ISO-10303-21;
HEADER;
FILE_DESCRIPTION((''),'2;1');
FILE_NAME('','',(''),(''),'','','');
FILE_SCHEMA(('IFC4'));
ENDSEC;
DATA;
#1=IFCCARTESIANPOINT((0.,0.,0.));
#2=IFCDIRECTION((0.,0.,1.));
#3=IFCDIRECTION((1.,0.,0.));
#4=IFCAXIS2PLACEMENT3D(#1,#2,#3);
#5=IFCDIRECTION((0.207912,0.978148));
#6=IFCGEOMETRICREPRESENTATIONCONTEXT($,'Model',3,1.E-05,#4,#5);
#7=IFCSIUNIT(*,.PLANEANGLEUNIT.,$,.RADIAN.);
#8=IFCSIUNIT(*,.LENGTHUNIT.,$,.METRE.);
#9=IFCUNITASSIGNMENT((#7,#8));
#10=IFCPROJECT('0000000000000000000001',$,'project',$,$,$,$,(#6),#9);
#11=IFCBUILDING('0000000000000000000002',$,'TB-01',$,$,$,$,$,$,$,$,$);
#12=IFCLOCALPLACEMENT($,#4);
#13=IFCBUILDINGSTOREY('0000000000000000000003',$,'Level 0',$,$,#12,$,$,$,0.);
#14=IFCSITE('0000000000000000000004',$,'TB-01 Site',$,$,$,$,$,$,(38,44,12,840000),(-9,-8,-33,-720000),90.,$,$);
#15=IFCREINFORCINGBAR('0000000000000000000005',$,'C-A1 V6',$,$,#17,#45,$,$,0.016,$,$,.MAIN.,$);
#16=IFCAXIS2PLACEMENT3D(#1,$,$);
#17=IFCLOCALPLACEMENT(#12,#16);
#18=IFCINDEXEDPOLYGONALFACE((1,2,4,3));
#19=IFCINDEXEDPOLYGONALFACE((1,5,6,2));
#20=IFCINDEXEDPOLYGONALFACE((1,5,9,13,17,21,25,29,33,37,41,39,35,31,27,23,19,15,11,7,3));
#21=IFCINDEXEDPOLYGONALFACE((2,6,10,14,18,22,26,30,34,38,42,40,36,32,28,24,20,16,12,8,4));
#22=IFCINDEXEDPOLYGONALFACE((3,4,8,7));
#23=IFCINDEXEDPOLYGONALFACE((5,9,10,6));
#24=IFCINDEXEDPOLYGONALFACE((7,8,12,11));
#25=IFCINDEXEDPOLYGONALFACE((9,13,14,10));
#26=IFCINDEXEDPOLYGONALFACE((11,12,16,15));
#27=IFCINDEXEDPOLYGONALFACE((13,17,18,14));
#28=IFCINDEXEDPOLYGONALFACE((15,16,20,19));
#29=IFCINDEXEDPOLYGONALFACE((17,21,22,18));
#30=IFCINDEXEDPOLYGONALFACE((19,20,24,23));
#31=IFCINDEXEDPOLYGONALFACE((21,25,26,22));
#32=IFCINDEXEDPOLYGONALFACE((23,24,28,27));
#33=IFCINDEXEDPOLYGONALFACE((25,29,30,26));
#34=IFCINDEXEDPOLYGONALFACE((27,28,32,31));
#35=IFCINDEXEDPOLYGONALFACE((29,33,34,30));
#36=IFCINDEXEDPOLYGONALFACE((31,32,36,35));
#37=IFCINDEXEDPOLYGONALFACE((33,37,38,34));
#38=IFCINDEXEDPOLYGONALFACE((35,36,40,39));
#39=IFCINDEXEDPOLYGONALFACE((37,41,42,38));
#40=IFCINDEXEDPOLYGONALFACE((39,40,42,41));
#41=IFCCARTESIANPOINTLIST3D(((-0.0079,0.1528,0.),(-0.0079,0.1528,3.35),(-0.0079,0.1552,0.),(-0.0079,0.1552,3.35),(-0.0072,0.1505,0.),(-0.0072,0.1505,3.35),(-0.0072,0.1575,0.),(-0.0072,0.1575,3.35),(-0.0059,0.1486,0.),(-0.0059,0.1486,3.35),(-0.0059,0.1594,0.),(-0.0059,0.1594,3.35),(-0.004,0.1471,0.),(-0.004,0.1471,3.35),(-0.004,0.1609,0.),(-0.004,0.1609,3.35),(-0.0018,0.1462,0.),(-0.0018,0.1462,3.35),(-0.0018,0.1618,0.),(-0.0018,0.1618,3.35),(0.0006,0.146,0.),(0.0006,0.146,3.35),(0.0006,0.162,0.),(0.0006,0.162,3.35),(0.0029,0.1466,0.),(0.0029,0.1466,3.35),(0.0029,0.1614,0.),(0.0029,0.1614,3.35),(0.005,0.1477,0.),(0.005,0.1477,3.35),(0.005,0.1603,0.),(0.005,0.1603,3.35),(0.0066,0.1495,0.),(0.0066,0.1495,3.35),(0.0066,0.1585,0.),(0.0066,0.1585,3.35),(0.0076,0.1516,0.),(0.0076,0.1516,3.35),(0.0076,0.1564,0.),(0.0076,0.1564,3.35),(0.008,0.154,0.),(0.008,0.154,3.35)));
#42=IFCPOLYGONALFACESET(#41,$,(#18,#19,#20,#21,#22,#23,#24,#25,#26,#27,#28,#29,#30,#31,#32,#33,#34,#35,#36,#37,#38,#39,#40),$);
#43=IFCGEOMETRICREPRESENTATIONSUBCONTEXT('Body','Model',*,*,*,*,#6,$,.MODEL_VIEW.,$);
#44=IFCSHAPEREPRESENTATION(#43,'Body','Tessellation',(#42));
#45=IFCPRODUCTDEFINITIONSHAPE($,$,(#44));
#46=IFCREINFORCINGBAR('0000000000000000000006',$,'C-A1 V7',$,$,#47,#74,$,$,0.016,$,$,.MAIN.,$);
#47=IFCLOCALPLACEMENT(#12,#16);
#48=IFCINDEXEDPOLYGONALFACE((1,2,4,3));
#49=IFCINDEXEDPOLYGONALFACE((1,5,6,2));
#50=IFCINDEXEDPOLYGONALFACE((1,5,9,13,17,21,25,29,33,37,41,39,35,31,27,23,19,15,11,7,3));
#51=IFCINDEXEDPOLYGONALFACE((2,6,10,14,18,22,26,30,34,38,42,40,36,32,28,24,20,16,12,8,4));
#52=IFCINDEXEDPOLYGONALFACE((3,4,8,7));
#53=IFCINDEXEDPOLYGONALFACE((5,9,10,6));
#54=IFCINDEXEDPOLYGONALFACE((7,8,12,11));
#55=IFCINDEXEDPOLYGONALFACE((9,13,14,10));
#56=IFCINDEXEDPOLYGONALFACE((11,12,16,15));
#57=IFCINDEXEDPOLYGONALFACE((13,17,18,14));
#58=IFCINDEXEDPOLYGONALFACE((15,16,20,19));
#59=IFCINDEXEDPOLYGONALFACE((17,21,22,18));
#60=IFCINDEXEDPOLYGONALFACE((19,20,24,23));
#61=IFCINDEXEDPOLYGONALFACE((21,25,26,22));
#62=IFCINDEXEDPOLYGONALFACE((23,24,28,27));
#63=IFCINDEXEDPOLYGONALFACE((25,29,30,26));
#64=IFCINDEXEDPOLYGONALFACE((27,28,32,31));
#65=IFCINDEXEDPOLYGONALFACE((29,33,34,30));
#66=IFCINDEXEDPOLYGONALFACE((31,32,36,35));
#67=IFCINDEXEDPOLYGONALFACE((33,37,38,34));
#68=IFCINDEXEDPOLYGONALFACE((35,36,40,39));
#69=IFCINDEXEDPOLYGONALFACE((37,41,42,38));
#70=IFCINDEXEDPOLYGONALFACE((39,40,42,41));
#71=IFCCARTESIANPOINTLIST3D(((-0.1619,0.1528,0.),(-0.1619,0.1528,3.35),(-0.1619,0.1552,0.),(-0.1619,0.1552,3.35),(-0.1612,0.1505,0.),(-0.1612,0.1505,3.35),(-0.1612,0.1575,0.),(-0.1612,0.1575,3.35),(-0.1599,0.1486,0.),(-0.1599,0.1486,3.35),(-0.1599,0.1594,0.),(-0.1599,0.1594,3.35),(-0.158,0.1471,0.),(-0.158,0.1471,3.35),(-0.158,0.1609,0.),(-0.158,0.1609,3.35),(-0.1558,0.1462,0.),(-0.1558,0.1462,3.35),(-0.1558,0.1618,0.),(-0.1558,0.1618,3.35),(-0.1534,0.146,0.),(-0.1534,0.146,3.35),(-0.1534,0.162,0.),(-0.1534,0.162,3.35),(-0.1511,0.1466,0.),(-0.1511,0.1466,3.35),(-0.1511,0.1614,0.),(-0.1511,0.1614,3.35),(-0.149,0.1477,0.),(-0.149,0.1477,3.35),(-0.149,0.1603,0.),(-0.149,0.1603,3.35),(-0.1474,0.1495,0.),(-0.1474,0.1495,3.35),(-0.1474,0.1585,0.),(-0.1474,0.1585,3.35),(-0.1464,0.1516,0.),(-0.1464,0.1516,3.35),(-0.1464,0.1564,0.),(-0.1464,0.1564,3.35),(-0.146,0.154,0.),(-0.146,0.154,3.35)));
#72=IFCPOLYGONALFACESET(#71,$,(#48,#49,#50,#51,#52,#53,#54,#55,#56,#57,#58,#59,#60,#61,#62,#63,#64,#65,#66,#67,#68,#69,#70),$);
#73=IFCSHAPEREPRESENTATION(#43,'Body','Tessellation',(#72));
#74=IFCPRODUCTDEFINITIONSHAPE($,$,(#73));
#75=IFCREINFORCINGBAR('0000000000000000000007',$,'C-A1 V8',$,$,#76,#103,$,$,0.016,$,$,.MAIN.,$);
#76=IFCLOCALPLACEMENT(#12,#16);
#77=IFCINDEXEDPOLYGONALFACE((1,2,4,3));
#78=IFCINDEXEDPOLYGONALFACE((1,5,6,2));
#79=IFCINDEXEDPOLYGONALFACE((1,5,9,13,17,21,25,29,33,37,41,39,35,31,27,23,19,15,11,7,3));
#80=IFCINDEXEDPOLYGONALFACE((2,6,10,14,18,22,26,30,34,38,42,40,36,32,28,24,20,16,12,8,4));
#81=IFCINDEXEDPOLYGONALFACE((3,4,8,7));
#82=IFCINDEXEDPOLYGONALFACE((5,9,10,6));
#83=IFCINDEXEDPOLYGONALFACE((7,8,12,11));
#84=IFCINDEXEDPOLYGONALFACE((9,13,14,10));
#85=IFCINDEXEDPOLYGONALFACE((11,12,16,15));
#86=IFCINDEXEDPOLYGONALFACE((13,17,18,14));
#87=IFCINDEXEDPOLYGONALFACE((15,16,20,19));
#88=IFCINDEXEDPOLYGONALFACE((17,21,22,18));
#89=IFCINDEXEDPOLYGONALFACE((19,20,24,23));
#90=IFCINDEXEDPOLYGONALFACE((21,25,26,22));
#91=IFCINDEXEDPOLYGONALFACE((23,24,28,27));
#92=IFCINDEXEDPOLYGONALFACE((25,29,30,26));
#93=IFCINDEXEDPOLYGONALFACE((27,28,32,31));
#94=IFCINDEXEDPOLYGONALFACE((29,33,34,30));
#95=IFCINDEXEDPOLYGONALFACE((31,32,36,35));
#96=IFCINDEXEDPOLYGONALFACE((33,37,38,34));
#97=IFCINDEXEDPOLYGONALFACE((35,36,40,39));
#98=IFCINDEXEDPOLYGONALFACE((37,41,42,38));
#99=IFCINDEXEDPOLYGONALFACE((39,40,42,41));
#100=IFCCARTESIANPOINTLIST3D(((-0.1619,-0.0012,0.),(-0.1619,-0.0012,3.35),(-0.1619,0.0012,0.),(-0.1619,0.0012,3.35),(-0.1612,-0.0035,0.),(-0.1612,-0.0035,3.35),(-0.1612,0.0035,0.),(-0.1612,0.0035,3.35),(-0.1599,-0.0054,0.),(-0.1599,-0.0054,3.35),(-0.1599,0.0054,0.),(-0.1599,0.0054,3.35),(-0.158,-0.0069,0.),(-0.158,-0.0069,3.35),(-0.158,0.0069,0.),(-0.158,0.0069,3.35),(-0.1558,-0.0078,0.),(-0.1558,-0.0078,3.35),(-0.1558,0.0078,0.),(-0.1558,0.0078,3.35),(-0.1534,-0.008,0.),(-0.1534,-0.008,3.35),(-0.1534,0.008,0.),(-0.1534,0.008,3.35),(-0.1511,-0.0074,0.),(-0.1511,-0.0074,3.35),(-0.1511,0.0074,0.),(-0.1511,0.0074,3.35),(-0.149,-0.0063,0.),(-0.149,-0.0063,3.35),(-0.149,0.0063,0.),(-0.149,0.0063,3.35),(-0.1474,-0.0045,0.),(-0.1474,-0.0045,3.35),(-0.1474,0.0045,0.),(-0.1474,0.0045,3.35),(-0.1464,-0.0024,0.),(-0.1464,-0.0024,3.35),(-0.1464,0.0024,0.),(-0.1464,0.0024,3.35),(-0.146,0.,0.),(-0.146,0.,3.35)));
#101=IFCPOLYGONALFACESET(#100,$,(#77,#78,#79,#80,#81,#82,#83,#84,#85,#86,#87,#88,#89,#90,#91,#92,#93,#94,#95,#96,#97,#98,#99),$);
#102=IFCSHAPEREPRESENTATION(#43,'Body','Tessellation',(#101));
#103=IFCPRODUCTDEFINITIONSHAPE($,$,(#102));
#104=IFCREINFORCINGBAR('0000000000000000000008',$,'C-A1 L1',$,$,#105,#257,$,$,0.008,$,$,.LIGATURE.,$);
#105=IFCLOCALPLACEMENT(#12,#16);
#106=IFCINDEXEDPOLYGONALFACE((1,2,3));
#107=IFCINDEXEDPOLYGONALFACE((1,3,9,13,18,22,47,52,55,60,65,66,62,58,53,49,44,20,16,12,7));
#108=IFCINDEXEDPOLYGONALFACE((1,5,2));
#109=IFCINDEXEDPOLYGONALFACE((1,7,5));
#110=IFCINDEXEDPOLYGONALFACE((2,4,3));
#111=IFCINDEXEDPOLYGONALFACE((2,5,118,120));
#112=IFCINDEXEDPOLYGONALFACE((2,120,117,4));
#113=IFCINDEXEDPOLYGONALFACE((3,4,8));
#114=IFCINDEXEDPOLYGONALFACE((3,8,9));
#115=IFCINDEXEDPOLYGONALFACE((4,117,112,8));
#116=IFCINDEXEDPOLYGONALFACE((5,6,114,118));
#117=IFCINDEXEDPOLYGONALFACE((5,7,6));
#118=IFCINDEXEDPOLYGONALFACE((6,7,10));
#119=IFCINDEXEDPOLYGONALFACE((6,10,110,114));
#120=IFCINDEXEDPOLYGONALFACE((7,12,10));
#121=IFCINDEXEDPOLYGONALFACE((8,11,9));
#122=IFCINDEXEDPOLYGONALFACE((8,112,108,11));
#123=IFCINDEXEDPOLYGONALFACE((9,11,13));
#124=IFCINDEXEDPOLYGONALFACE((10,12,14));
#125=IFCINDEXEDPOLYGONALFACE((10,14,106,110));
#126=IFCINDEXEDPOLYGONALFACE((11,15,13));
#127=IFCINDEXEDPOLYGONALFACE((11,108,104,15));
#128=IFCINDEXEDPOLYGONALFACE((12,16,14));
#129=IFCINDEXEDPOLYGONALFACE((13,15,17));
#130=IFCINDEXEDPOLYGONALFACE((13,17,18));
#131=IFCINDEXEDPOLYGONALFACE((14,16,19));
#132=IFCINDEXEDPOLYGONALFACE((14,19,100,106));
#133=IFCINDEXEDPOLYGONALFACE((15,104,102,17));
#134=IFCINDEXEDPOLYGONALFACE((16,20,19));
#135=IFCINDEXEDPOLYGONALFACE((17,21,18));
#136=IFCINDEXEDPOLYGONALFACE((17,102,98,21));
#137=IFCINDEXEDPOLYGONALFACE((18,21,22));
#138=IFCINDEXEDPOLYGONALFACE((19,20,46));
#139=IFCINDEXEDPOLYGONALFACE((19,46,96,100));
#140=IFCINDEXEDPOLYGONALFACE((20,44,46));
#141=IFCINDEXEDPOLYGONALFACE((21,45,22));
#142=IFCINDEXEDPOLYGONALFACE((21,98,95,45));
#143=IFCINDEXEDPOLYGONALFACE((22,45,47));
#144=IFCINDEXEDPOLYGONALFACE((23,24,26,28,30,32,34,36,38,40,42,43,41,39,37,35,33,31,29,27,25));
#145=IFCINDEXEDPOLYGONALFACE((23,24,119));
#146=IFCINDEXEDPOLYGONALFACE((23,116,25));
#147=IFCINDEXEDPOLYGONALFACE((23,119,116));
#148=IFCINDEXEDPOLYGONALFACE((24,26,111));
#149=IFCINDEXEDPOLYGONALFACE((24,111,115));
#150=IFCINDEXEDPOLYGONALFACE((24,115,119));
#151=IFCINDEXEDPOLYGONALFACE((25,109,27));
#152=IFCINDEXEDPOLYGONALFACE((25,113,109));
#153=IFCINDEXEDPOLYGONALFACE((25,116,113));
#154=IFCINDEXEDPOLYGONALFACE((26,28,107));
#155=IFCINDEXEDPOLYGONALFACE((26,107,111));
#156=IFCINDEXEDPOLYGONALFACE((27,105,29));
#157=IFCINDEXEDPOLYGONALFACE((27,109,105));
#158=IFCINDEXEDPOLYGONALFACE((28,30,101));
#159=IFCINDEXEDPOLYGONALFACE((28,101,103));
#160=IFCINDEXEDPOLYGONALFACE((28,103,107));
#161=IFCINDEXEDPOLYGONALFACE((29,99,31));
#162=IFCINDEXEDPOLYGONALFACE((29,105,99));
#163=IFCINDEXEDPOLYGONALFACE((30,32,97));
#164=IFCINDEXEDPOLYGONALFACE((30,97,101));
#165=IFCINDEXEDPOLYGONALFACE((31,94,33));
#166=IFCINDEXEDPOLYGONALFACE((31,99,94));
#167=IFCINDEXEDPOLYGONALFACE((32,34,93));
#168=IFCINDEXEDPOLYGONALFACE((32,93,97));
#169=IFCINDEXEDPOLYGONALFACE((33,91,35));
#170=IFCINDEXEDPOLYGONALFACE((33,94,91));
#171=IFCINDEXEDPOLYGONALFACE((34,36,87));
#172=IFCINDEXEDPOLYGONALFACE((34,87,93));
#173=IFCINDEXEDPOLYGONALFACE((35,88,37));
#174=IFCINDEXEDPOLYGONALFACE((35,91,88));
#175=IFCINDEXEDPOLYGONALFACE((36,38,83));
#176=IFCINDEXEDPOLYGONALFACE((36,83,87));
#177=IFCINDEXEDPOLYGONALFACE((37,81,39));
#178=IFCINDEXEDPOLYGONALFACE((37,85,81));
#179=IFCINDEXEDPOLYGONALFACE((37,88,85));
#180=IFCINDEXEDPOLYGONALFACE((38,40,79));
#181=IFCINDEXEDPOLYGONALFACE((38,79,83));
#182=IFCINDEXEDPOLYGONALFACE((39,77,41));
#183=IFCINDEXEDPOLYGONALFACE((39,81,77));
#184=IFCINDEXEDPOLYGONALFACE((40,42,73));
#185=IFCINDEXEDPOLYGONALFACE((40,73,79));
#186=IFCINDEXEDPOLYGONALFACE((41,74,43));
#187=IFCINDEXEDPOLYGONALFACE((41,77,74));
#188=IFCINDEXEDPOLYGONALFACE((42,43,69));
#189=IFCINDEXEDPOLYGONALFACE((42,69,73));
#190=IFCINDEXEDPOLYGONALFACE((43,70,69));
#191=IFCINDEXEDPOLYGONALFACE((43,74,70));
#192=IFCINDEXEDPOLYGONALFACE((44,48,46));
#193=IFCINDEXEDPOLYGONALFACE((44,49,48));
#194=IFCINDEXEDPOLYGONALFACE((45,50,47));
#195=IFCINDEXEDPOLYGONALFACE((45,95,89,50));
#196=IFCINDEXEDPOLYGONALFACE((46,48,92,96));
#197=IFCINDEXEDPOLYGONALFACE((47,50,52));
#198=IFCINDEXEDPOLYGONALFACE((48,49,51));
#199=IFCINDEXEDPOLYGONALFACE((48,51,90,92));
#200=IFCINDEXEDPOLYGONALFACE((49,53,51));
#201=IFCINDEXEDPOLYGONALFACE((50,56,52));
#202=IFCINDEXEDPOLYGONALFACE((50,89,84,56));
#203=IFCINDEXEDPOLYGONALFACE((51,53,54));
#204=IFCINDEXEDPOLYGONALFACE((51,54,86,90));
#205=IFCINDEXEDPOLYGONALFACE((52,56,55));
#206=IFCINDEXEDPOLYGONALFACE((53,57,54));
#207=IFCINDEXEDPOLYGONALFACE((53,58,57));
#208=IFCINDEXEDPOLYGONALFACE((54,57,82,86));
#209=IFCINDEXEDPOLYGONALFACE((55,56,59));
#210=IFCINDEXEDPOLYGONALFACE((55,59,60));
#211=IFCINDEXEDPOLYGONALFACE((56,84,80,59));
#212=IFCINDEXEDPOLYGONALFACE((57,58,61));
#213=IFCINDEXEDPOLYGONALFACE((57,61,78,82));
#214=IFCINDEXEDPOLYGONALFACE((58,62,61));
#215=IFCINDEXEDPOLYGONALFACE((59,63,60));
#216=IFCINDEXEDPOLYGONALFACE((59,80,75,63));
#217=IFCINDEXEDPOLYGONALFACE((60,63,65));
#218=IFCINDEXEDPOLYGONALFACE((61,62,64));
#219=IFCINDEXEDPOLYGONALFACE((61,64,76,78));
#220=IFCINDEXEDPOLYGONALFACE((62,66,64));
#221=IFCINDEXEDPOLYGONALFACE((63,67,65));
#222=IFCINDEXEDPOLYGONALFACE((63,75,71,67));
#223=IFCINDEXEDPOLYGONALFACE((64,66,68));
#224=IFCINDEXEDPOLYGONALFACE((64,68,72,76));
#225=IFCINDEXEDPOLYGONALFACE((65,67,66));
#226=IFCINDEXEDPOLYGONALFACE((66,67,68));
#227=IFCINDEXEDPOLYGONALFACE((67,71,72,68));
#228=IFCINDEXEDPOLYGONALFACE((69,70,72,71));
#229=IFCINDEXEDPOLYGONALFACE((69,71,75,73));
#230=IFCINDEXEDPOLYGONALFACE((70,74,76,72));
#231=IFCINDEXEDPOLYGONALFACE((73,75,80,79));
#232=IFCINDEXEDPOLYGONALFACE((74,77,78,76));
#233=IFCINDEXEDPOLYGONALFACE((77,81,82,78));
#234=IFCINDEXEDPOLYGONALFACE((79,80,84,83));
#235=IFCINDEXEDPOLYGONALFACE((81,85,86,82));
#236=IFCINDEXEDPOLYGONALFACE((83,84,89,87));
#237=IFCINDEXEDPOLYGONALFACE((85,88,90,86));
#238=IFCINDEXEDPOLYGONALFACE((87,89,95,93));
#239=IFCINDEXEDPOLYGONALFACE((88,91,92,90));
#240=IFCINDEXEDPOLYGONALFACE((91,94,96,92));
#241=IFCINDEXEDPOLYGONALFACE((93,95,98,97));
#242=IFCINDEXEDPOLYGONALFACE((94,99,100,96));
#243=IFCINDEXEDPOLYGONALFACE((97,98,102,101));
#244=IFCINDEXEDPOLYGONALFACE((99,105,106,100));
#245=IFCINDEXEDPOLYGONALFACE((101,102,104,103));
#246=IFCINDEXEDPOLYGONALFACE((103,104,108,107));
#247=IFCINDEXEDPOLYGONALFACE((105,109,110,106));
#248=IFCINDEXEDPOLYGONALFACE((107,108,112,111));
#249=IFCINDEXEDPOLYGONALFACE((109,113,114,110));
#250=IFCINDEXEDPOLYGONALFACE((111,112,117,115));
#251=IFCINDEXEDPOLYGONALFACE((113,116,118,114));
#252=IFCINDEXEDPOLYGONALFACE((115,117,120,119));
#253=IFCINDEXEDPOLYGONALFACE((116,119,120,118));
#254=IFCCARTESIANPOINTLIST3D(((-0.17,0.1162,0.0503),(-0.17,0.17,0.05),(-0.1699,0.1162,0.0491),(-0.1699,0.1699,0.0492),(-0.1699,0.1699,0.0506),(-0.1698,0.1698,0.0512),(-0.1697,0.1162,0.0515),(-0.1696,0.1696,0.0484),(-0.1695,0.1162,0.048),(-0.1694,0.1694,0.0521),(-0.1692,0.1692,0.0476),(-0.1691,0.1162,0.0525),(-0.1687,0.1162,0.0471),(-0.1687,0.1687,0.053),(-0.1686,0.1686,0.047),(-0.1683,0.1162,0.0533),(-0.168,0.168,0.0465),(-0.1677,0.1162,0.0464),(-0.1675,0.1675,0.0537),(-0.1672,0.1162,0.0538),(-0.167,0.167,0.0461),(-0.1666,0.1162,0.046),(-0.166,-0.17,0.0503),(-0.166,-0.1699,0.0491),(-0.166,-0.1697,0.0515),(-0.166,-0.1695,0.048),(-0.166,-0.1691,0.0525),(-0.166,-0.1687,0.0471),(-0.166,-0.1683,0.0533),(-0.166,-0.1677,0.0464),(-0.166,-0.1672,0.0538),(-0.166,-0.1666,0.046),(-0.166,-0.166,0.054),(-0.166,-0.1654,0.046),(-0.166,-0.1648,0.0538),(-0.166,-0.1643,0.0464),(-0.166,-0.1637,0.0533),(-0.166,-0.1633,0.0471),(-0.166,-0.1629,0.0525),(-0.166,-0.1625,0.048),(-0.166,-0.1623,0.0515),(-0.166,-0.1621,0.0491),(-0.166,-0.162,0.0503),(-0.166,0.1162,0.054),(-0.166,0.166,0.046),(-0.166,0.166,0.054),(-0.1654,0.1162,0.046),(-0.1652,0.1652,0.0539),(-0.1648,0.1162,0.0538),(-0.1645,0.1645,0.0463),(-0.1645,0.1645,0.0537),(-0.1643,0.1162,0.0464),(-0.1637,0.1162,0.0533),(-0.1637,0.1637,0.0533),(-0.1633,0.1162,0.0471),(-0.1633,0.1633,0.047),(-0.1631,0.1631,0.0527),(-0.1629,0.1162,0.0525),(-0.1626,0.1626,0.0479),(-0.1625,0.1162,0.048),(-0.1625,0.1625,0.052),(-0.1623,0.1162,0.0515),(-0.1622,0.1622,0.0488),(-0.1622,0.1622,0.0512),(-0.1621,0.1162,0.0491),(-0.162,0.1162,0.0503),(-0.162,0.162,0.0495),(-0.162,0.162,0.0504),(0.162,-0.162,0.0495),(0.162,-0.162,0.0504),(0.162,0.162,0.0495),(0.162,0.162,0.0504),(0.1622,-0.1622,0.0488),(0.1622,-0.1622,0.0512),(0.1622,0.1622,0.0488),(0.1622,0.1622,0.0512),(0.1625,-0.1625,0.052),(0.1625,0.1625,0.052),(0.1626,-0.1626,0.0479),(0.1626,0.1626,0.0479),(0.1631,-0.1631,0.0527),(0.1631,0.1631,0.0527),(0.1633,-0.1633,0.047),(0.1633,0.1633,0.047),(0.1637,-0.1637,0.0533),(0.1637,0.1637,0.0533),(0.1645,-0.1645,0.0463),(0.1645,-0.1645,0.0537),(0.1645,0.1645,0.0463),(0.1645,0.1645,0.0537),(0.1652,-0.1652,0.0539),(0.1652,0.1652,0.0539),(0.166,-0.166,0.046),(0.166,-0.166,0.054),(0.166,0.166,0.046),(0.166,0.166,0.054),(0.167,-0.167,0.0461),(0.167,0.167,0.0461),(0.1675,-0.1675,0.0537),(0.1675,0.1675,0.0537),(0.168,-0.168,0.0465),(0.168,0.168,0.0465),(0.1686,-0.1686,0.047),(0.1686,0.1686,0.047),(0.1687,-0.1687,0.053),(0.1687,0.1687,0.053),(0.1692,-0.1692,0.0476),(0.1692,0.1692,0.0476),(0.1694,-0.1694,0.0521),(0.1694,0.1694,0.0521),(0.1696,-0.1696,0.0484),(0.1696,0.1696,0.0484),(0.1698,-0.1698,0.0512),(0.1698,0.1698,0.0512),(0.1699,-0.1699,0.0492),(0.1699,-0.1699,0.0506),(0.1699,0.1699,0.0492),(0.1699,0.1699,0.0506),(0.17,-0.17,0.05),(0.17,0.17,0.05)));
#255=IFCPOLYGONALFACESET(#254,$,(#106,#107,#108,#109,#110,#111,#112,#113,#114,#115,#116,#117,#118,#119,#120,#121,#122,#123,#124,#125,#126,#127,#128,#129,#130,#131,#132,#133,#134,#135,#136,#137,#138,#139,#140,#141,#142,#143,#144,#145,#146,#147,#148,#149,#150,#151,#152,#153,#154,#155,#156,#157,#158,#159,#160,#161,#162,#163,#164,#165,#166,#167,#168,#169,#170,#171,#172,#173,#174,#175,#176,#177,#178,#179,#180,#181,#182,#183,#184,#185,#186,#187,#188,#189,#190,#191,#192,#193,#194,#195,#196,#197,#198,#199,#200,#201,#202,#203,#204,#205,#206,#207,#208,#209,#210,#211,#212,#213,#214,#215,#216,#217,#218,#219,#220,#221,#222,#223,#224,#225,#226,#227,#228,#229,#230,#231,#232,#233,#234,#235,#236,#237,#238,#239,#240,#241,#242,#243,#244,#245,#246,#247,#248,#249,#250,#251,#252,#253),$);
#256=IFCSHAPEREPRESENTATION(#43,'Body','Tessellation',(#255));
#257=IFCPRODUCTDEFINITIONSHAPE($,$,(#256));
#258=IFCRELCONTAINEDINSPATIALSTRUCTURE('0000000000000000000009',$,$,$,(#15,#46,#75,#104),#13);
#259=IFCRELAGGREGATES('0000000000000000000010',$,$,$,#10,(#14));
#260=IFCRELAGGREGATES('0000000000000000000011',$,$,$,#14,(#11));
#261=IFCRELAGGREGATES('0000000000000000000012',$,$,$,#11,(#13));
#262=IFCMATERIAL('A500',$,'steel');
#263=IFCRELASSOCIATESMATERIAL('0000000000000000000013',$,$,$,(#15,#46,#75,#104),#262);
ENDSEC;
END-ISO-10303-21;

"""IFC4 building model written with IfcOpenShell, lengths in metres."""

from ifc_helpers import new_model, entity, si_unit, direction, origin_with_axes, place, context, subcontext, project, spatial, material, element, save


model = new_model("IFC4")

# Units and contexts
model_context = context("Model", 3, precision=1e-05, world=origin_with_axes(), true_north=direction((0.207912, 0.978148)))
body_context = subcontext(model_context, "Body", "Model", "MODEL_VIEW")
ifc_project = project(units=[si_unit("PLANEANGLEUNIT", "RADIAN"), si_unit("LENGTHUNIT", "METRE")], contexts=[model_context])

# Site, building, storey
site = spatial("IfcSite", under=ifc_project, Name="TB-01 Site", RefLatitude=(38, 44, 12, 840000), RefLongitude=(-9, -8, -33, -720000), RefElevation=90.0)
building = spatial("IfcBuilding", under=site, Name="TB-01")
storey_placement = place(None, origin_with_axes())
storey = spatial("IfcBuildingStorey", under=building, at=storey_placement, Name="Level 0", Elevation=0.0)

# Reinforcing bars
ifc_material_1 = material(Name="A500", Category="steel")
reinforcing_bar_1_placement = place(storey_placement, origin_with_axes())
element("IfcReinforcingBar", 1, at=reinforcing_bar_1_placement, inside=storey, material=ifc_material_1, Name="C-A1 V6", NominalDiameter=0.016, PredefinedType="MAIN", context=body_context, shape_type="AdvancedSweptSolid", body=[
    entity("IfcSweptDiskSolid", entity("IfcPolyline", [entity("IfcCartesianPoint", [0.0, 0.154, 0.0]), entity("IfcCartesianPoint", [0.0, 0.154, 3.35])]), 0.008),
])
reinforcing_bar_2_placement = place(storey_placement, origin_with_axes())
element("IfcReinforcingBar", 2, at=reinforcing_bar_2_placement, inside=storey, material=ifc_material_1, Name="C-A1 V7", NominalDiameter=0.016, PredefinedType="MAIN", context=body_context, shape_type="AdvancedSweptSolid", body=[
    entity("IfcSweptDiskSolid", entity("IfcPolyline", [entity("IfcCartesianPoint", [-0.154, 0.154, 0.0]), entity("IfcCartesianPoint", [-0.154, 0.154, 3.35])]), 0.008),
])
reinforcing_bar_3_placement = place(storey_placement, origin_with_axes())
element("IfcReinforcingBar", 3, at=reinforcing_bar_3_placement, inside=storey, material=ifc_material_1, Name="C-A1 V8", NominalDiameter=0.016, PredefinedType="MAIN", context=body_context, shape_type="AdvancedSweptSolid", body=[
    entity("IfcSweptDiskSolid", entity("IfcPolyline", [entity("IfcCartesianPoint", [-0.154, 0.0, 0.0]), entity("IfcCartesianPoint", [-0.154, 0.0, 3.35])]), 0.008),
])
reinforcing_bar_4_placement = place(storey_placement, origin_with_axes())
element("IfcReinforcingBar", 4, at=reinforcing_bar_4_placement, inside=storey, material=ifc_material_1, Name="C-A1 L1", NominalDiameter=0.008, PredefinedType="LIGATURE", context=body_context, shape_type="AdvancedSweptSolid", body=[
    entity("IfcSweptDiskSolid", entity("IfcPolyline", [entity("IfcCartesianPoint", [-0.166, -0.166, 0.05]), entity("IfcCartesianPoint", [0.166, -0.166, 0.05]), entity("IfcCartesianPoint", [0.166, 0.166, 0.05]), entity("IfcCartesianPoint", [-0.166, 0.166, 0.05]), entity("IfcCartesianPoint", [-0.166, 0.1162, 0.05])]), 0.004),
])

save(model, "model.ifc")
